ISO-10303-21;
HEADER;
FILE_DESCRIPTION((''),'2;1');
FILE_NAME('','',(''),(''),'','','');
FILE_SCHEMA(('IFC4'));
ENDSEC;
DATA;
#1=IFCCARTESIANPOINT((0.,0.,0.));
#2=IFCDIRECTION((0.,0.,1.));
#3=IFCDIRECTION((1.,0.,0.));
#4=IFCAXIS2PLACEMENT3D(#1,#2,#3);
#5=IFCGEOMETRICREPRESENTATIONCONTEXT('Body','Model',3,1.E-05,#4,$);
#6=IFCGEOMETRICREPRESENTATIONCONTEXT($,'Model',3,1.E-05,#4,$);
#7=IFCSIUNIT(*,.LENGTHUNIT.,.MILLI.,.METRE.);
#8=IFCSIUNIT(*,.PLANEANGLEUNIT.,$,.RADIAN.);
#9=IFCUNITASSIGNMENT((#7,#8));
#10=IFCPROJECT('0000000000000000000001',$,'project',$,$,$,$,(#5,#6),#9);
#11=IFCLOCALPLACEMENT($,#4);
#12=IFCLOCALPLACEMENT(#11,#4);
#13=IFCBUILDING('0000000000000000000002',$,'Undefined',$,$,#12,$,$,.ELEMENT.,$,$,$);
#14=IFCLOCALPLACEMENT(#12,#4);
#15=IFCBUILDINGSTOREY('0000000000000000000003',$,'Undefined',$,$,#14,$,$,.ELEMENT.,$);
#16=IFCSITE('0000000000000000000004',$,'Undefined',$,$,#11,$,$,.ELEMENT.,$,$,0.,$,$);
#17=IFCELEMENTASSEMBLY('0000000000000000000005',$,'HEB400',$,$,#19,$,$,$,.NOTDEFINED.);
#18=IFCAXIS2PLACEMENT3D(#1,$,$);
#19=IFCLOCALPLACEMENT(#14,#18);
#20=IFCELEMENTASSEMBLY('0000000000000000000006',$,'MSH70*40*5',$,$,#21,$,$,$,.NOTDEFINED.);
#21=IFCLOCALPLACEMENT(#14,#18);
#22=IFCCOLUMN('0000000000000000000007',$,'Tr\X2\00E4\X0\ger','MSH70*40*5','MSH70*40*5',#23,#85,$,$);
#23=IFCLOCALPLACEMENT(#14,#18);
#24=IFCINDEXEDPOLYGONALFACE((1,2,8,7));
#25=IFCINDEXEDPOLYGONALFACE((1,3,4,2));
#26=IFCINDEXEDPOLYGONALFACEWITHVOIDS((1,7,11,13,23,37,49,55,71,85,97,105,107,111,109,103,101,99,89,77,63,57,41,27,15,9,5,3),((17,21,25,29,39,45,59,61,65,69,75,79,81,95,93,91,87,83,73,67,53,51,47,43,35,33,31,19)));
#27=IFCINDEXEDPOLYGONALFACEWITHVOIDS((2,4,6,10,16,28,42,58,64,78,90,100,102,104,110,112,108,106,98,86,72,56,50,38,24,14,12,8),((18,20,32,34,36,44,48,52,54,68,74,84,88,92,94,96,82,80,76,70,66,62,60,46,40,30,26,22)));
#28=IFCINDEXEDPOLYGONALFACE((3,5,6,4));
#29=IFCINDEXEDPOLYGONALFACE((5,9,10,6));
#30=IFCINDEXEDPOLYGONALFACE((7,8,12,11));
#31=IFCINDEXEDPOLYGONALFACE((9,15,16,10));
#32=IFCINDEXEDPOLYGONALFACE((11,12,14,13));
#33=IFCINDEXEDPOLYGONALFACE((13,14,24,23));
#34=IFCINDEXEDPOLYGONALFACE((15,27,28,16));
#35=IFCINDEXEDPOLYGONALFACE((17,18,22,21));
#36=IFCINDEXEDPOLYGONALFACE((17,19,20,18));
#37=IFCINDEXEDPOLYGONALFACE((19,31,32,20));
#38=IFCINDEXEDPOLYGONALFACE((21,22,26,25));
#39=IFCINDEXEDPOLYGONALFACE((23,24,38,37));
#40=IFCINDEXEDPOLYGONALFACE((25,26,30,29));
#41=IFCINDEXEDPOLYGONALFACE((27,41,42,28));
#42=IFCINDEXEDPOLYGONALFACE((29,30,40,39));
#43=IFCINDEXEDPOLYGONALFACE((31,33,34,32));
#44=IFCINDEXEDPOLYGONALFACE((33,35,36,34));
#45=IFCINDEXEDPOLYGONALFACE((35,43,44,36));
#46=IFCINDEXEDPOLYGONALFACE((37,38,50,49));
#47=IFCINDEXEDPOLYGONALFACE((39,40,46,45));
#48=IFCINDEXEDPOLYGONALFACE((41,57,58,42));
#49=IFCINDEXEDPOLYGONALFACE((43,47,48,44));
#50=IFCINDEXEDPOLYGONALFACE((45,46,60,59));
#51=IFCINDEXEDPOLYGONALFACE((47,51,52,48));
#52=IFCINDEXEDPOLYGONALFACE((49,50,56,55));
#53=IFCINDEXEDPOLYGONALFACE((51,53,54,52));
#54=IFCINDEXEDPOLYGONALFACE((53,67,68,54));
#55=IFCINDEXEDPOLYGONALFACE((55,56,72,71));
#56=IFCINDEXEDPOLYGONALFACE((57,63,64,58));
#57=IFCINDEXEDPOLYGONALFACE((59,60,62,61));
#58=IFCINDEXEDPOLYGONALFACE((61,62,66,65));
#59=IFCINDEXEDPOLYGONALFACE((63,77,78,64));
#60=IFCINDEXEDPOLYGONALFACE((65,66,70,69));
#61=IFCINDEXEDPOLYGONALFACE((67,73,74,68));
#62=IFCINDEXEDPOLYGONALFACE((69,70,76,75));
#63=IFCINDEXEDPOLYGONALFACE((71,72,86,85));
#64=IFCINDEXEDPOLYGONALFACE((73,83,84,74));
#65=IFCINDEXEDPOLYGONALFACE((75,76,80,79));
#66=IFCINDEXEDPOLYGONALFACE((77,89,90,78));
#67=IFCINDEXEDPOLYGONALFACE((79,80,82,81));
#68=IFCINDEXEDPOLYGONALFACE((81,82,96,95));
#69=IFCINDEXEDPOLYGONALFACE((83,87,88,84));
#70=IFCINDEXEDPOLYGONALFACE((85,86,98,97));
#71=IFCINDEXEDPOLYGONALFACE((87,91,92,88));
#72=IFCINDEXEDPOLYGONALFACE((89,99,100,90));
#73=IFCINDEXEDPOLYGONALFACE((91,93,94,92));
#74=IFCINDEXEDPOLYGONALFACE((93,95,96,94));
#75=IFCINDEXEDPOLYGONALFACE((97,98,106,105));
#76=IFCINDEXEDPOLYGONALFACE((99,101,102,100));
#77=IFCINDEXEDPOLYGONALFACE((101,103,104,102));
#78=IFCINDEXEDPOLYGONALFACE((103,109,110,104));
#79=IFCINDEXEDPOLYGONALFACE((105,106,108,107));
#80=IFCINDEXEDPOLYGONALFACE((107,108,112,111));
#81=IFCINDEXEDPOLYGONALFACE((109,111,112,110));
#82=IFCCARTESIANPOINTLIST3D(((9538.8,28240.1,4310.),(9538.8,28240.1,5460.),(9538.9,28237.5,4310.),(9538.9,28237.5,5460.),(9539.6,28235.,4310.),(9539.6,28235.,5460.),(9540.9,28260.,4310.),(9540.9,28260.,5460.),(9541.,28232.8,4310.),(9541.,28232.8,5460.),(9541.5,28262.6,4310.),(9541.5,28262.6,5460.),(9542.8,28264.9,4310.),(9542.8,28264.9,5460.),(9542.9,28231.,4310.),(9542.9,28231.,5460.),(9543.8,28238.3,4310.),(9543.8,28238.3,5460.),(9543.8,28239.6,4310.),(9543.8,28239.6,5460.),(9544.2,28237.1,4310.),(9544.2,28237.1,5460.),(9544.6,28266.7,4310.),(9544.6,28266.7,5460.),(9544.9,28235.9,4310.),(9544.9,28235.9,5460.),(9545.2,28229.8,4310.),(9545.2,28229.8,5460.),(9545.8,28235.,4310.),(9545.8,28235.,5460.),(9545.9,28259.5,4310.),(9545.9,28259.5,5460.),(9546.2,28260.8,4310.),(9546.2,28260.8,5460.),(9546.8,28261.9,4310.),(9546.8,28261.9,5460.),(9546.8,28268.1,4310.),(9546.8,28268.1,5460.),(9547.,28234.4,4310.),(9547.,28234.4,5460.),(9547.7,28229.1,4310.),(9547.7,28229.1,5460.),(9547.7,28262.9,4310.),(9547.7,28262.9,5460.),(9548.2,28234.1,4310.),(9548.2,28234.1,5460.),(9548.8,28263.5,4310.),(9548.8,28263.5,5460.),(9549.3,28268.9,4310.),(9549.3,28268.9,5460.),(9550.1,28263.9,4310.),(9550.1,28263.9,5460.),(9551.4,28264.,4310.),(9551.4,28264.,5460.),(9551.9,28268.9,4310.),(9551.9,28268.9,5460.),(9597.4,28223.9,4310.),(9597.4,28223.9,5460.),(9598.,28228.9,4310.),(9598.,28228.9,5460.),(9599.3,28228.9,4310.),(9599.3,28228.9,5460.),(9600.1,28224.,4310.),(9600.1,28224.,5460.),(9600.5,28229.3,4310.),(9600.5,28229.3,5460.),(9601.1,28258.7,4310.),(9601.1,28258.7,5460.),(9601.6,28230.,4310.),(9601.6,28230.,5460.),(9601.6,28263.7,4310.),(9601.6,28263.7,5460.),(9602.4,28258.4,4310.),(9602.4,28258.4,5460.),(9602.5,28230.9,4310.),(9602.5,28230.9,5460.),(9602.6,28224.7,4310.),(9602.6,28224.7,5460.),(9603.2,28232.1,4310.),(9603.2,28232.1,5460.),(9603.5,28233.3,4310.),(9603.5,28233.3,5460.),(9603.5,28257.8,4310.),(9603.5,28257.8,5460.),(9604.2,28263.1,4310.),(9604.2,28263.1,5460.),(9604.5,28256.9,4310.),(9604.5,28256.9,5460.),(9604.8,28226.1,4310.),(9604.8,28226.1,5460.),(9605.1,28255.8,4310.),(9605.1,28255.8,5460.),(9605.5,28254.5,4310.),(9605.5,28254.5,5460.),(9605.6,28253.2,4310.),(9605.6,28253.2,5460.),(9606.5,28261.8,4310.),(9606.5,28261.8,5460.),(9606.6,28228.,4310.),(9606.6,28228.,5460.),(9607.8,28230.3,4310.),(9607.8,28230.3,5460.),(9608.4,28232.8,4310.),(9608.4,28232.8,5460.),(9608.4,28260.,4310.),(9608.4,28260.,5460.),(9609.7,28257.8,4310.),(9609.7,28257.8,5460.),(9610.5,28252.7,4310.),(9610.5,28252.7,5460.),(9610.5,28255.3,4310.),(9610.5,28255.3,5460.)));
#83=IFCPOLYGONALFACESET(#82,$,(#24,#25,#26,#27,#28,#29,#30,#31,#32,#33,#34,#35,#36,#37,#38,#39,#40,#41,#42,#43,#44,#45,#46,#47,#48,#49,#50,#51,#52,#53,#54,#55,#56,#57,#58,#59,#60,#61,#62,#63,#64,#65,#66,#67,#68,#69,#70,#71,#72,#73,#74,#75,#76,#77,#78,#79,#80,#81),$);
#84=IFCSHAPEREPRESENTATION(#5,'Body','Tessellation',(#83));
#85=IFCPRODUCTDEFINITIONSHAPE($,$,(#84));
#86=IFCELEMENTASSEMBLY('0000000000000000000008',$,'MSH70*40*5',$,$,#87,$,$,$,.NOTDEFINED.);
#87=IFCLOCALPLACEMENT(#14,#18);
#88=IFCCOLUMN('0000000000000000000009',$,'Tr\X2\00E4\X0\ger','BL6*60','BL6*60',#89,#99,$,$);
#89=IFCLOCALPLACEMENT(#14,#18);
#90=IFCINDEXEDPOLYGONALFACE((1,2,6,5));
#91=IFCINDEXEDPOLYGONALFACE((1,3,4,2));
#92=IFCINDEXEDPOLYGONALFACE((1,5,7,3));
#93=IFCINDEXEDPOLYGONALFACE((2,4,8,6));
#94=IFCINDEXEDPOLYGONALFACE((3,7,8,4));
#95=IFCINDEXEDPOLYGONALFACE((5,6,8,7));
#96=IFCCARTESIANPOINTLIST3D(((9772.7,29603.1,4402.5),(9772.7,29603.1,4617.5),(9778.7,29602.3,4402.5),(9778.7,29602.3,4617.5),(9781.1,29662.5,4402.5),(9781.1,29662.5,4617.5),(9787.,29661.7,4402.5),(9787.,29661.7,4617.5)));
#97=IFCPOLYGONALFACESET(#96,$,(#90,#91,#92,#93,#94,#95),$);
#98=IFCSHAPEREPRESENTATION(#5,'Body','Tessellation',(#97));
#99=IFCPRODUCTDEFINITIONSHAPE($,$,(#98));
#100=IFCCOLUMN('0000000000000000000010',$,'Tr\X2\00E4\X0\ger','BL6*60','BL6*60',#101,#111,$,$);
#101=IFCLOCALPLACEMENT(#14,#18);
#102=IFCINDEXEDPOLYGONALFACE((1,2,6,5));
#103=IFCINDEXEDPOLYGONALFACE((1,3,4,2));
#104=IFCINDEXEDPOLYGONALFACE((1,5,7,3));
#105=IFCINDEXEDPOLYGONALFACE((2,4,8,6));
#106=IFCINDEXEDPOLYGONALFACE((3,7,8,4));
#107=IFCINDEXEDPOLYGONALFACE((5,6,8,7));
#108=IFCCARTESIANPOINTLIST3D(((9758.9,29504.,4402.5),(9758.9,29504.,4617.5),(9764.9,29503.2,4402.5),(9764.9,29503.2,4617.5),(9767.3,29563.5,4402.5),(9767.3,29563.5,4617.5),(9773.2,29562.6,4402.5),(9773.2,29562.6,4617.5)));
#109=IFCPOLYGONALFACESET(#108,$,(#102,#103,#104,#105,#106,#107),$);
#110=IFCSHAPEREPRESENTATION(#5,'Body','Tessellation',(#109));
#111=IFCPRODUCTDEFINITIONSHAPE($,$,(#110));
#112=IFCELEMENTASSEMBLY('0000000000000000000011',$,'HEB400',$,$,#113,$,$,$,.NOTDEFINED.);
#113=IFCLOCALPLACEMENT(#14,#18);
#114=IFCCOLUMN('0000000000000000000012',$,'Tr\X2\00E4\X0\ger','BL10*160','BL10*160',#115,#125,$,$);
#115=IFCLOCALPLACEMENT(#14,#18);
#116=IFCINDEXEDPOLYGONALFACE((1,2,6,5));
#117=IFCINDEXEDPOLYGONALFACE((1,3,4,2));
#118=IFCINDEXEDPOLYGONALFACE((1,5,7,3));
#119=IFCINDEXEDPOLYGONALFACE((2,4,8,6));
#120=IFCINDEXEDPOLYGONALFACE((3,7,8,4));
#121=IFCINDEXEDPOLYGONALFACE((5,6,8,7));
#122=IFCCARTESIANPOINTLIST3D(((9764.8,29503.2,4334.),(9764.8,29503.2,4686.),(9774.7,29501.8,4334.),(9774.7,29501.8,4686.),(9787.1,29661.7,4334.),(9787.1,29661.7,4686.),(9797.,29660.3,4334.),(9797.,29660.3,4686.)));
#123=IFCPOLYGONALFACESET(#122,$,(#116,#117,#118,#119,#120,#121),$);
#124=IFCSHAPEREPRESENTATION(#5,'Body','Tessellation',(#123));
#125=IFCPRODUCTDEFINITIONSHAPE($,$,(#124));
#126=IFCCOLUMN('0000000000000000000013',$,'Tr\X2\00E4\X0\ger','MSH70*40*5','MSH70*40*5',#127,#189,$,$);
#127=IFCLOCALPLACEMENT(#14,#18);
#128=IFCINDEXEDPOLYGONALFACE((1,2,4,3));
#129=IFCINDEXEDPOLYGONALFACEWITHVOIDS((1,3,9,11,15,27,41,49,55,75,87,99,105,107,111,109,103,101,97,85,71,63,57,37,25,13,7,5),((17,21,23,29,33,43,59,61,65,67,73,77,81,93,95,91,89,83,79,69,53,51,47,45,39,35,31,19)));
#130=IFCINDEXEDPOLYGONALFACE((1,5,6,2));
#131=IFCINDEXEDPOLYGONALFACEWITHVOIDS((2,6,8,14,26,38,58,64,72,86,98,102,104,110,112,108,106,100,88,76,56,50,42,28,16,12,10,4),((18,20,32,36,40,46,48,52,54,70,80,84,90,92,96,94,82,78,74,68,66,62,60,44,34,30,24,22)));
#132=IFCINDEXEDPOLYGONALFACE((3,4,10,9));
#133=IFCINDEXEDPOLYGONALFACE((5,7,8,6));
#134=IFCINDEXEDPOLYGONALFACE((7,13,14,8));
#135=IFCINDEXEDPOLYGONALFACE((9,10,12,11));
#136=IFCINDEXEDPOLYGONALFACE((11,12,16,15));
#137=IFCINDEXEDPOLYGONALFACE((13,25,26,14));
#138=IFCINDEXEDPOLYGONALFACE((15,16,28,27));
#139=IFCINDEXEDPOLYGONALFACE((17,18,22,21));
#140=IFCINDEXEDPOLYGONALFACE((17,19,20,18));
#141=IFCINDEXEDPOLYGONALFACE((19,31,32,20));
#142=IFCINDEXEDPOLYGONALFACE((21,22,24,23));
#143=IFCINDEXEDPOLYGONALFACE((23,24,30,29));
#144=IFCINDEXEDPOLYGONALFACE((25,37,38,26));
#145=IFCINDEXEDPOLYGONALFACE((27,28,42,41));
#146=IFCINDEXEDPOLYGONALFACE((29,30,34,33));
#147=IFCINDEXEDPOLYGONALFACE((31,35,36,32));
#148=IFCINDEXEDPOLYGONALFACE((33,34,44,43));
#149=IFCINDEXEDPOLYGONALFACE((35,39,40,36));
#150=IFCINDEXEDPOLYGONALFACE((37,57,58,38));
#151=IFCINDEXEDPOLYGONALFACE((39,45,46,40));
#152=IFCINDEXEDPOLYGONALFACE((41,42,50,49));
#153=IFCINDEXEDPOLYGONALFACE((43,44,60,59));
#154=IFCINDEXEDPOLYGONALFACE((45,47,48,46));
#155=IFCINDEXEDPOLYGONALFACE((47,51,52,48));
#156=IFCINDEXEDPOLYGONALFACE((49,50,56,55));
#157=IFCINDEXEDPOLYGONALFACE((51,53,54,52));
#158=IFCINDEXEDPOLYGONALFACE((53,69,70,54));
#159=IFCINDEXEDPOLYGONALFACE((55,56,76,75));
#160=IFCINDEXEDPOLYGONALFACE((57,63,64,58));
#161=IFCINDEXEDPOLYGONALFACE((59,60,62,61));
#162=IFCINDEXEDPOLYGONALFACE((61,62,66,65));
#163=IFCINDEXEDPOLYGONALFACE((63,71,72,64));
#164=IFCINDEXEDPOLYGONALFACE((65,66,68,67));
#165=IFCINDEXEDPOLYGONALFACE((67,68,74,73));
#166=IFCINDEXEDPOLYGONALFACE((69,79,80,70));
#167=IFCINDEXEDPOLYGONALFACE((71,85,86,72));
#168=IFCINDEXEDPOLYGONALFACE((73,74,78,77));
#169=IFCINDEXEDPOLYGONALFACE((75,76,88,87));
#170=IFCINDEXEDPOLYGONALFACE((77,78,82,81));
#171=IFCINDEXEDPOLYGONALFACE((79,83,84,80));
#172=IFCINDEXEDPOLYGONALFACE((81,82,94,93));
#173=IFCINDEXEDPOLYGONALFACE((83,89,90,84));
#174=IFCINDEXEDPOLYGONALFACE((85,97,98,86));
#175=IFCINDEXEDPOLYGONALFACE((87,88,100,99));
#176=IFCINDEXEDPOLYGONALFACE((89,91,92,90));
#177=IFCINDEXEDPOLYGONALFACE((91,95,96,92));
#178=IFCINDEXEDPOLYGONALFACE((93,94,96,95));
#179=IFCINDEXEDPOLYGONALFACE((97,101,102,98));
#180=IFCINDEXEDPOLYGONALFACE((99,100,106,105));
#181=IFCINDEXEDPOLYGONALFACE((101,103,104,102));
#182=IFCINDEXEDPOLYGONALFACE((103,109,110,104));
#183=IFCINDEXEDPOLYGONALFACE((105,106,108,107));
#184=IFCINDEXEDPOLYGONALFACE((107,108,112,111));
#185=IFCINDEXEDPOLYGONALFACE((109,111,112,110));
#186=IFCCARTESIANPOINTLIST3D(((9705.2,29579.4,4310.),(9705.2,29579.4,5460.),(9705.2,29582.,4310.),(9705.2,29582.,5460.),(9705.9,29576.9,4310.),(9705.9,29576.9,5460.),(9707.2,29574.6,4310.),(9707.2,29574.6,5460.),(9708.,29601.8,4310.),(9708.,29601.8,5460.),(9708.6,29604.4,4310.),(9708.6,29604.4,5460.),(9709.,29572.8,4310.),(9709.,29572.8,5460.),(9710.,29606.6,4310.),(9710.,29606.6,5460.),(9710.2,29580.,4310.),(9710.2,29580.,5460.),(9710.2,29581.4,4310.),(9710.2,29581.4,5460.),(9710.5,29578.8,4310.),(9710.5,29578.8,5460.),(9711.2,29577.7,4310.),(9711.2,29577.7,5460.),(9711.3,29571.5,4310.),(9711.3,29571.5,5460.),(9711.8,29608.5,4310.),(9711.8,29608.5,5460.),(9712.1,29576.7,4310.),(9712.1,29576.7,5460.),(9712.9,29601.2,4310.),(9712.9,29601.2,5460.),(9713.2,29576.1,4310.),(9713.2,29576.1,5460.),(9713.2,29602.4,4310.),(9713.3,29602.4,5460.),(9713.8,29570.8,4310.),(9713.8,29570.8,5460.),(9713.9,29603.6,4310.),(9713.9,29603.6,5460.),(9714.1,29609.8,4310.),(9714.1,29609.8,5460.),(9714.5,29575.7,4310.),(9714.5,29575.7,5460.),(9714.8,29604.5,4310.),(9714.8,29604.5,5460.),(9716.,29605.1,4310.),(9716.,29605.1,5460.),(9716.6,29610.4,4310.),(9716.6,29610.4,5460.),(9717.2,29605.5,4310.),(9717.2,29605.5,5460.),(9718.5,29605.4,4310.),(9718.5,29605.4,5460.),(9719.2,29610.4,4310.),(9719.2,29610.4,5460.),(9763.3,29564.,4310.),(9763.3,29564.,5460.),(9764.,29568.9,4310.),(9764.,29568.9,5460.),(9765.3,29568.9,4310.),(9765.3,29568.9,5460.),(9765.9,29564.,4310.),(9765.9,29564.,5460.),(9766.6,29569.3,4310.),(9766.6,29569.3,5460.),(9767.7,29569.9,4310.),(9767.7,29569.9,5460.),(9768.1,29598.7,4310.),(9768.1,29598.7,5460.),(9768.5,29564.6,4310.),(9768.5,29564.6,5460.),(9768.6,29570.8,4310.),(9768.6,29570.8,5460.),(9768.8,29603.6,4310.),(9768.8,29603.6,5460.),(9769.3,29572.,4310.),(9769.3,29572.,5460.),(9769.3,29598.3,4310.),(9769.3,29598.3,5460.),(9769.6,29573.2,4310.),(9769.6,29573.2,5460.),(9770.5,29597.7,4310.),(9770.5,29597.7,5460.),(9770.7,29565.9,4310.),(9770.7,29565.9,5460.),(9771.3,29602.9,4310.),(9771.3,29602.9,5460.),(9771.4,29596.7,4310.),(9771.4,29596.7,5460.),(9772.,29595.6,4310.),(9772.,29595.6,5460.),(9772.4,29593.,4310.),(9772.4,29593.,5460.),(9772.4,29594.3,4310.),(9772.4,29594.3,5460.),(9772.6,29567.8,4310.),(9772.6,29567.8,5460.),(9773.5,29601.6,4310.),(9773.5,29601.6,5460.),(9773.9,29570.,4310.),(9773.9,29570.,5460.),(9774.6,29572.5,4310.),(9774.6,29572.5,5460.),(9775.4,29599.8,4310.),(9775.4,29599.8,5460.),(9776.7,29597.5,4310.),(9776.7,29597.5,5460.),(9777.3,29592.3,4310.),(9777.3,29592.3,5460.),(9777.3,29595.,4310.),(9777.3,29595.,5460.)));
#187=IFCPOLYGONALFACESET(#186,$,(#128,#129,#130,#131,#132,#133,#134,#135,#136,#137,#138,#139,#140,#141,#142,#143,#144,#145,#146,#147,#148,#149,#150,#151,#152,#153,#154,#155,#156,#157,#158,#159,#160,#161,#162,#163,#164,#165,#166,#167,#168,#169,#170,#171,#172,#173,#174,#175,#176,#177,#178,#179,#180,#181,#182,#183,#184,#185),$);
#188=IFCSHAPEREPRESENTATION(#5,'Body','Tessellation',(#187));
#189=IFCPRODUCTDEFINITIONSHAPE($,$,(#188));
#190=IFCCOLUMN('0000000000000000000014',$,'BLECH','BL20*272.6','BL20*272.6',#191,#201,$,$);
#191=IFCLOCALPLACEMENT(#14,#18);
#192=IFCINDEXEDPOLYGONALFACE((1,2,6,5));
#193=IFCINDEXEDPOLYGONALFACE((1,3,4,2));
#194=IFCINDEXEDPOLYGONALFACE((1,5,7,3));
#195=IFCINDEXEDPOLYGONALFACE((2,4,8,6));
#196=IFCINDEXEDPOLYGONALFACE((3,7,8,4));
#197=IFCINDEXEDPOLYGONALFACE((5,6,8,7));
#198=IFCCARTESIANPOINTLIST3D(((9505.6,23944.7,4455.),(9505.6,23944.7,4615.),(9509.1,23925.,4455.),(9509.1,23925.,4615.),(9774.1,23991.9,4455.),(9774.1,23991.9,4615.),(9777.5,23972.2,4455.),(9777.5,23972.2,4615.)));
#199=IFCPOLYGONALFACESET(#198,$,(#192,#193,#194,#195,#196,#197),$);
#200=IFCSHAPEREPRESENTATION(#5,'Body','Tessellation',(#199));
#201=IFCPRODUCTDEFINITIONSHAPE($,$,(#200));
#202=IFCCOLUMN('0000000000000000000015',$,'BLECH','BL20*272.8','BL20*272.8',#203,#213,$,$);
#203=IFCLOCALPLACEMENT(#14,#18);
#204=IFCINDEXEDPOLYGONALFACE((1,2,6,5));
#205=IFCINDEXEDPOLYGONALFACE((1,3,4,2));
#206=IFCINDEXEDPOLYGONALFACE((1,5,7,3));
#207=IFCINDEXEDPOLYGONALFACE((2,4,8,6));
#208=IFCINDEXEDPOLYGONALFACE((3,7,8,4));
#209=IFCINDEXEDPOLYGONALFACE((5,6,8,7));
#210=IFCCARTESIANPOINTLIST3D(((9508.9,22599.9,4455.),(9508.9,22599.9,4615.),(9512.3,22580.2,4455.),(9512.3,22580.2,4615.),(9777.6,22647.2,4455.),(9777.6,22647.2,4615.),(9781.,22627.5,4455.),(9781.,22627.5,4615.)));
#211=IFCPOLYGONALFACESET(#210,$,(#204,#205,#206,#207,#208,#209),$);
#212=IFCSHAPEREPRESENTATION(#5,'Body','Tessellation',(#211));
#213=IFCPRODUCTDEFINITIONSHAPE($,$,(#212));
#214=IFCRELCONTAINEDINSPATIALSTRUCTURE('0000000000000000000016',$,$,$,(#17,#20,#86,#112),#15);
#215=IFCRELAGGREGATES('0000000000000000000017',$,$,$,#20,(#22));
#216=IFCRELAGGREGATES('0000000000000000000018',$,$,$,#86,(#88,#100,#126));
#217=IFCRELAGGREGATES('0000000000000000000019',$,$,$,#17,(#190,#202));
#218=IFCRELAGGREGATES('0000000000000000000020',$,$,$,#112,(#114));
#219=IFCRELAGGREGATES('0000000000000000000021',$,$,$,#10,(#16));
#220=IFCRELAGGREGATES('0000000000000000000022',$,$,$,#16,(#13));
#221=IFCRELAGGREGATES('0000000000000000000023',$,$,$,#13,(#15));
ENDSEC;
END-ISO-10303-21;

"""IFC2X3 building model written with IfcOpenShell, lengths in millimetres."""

from ifc_helpers import new_model, si_unit, frame, origin_with_axes, origin_2d_with_axis, place, context, project, spatial, rectangle, hollow_rectangle, extrude, element, aggregate, save


model = new_model("IFC2X3")

# Units and contexts
model_context_1 = context("Model", 3, precision=1e-05, world=origin_with_axes(), identifier="Body")
model_context_2 = context("Model", 3, precision=1e-05, world=origin_with_axes())
ifc_project = project(units=[si_unit("LENGTHUNIT", "METRE", prefix="MILLI"), si_unit("PLANEANGLEUNIT", "RADIAN")], contexts=[model_context_1, model_context_2])

# Site, building, storey
site_placement = place(None, origin_with_axes())
site = spatial("IfcSite", under=ifc_project, at=site_placement, Name="Undefined", CompositionType="ELEMENT", RefElevation=0.0)
building_placement = place(site_placement, origin_with_axes())
building = spatial("IfcBuilding", under=site, at=building_placement, Name="Undefined", CompositionType="ELEMENT")
storey_placement = place(building_placement, origin_with_axes())
storey = spatial("IfcBuildingStorey", under=building, at=storey_placement, Name="Undefined", CompositionType="ELEMENT")

# Element assembly
assembly_1 = element("IfcElementAssembly", 1, inside=storey, Name="HEB400", PredefinedType="NOTDEFINED")

# Element assembly
assembly_2 = element("IfcElementAssembly", 2, inside=storey, Name="MSH70*40*5", PredefinedType="NOTDEFINED")

# Column
column_1_placement = place(storey_placement, frame((9574.7, 28246.4, 4310.0), z_axis=(0.0, 0.0, 1.0), x_axis=(1.0, 0.0, 0.0)))
column_1 = element("IfcColumn", 3, at=column_1_placement, Name="Träger", Description="MSH70*40*5", ObjectType="MSH70*40*5", context=model_context_1, shape_type="SweptSolid", body=[
    extrude(hollow_rectangle(XDim=40.0, YDim=70.0, WallThickness=5.0, InnerFilletRadius=5.0, OuterFilletRadius=10.0, at=origin_2d_with_axis()), frame((0.0, 0.0, 1150.0), z_axis=(0.0, 0.0, -1.0), x_axis=(-0.104529, -0.994522, 0.0)), (0.0, 0.0, 1.0), 1150.0),
])
aggregate(assembly_2, [column_1])

# Element assembly, columns
assembly_3 = element("IfcElementAssembly", 4, inside=storey, Name="MSH70*40*5", PredefinedType="NOTDEFINED")
column_2_placement = place(storey_placement, frame((9779.9, 29632.4, 4402.5), z_axis=(0.0, 0.0, 1.0), x_axis=(1.0, 0.0, 0.0)))
column_2 = element("IfcColumn", 5, at=column_2_placement, Name="Träger", Description="BL6*60", ObjectType="BL6*60", context=model_context_1, shape_type="SweptSolid", body=[
    extrude(rectangle(XDim=6.0, YDim=60.0, at=origin_2d_with_axis()), frame((0.0, 0.0, 215.0), z_axis=(0.0, 0.0, -1.0), x_axis=(-0.990268, 0.139173, 0.0)), (0.0, 0.0, 1.0), 215.0),
])
column_3_placement = place(storey_placement, frame((9766.1, 29533.3, 4402.5), z_axis=(0.0, 0.0, 1.0), x_axis=(1.0, 0.0, 0.0)))
column_3 = element("IfcColumn", 6, at=column_3_placement, Name="Träger", Description="BL6*60", ObjectType="BL6*60", context=model_context_1, shape_type="SweptSolid", body=[
    extrude(rectangle(XDim=6.0, YDim=60.0, at=origin_2d_with_axis()), frame((0.0, 0.0, 215.0), z_axis=(0.0, 0.0, -1.0), x_axis=(-0.990268, 0.139173, 0.0)), (0.0, 0.0, 1.0), 215.0),
])

# Element assembly, column
assembly_4 = element("IfcElementAssembly", 7, inside=storey, Name="HEB400", PredefinedType="NOTDEFINED")
column_4_placement = place(storey_placement, frame((9780.9, 29581.7, 4334.0), z_axis=(0.0, 0.0, 1.0), x_axis=(1.0, 0.0, 0.0)))
column_4 = element("IfcColumn", 8, at=column_4_placement, Name="Träger", Description="BL10*160", ObjectType="BL10*160", context=model_context_1, shape_type="SweptSolid", body=[
    extrude(rectangle(XDim=10.0, YDim=160.0, at=origin_2d_with_axis()), frame((0.0, 0.0, 352.0), z_axis=(0.0, 0.0, -1.0), x_axis=(-0.990268, 0.139173, 0.0)), (0.0, 0.0, 1.0), 352.0),
])

# Columns
column_5_placement = place(storey_placement, frame((9741.3, 29587.2, 4310.0), z_axis=(0.0, 0.0, 1.0), x_axis=(1.0, 0.0, 0.0)))
column_5 = element("IfcColumn", 9, at=column_5_placement, Name="Träger", Description="MSH70*40*5", ObjectType="MSH70*40*5", context=model_context_1, shape_type="SweptSolid", body=[
    extrude(hollow_rectangle(XDim=40.0, YDim=70.0, WallThickness=5.0, InnerFilletRadius=5.0, OuterFilletRadius=10.0, at=origin_2d_with_axis()), frame((0.0, 0.0, 1150.0), z_axis=(0.0, 0.0, -1.0), x_axis=(-0.135716, -0.990748, 0.0)), (0.0, 0.0, 1.0), 1150.0),
])
aggregate(assembly_3, [column_2, column_3, column_5])
column_6_placement = place(storey_placement, frame((9641.6, 23958.4, 4455.0), z_axis=(0.0, 0.0, 1.0), x_axis=(1.0, 0.0, 0.0)))
column_6 = element("IfcColumn", 10, at=column_6_placement, Name="BLECH", Description="BL20*272.6", ObjectType="BL20*272.6", context=model_context_1, shape_type="SweptSolid", body=[
    extrude(rectangle(XDim=20.0, YDim=272.6, at=origin_2d_with_axis()), frame((0.0, 0.0, 160.0), z_axis=(0.0, 0.0, -1.0), x_axis=(0.173304, -0.984868, 0.0)), (0.0, 0.0, 1.0), 160.0),
])
column_7_placement = place(storey_placement, frame((9645.0, 22613.7, 4455.0), z_axis=(0.0, 0.0, 1.0), x_axis=(1.0, 0.0, 0.0)))
column_7 = element("IfcColumn", 11, at=column_7_placement, Name="BLECH", Description="BL20*272.8", ObjectType="BL20*272.8", context=model_context_1, shape_type="SweptSolid", body=[
    extrude(rectangle(XDim=20.0, YDim=272.8, at=origin_2d_with_axis()), frame((0.0, 0.0, 160.0), z_axis=(0.0, 0.0, -1.0), x_axis=(0.173304, -0.984868, 0.0)), (0.0, 0.0, 1.0), 160.0),
])

aggregate(assembly_1, [column_6, column_7])
aggregate(assembly_4, [column_4])

save(model, "model.ifc")
